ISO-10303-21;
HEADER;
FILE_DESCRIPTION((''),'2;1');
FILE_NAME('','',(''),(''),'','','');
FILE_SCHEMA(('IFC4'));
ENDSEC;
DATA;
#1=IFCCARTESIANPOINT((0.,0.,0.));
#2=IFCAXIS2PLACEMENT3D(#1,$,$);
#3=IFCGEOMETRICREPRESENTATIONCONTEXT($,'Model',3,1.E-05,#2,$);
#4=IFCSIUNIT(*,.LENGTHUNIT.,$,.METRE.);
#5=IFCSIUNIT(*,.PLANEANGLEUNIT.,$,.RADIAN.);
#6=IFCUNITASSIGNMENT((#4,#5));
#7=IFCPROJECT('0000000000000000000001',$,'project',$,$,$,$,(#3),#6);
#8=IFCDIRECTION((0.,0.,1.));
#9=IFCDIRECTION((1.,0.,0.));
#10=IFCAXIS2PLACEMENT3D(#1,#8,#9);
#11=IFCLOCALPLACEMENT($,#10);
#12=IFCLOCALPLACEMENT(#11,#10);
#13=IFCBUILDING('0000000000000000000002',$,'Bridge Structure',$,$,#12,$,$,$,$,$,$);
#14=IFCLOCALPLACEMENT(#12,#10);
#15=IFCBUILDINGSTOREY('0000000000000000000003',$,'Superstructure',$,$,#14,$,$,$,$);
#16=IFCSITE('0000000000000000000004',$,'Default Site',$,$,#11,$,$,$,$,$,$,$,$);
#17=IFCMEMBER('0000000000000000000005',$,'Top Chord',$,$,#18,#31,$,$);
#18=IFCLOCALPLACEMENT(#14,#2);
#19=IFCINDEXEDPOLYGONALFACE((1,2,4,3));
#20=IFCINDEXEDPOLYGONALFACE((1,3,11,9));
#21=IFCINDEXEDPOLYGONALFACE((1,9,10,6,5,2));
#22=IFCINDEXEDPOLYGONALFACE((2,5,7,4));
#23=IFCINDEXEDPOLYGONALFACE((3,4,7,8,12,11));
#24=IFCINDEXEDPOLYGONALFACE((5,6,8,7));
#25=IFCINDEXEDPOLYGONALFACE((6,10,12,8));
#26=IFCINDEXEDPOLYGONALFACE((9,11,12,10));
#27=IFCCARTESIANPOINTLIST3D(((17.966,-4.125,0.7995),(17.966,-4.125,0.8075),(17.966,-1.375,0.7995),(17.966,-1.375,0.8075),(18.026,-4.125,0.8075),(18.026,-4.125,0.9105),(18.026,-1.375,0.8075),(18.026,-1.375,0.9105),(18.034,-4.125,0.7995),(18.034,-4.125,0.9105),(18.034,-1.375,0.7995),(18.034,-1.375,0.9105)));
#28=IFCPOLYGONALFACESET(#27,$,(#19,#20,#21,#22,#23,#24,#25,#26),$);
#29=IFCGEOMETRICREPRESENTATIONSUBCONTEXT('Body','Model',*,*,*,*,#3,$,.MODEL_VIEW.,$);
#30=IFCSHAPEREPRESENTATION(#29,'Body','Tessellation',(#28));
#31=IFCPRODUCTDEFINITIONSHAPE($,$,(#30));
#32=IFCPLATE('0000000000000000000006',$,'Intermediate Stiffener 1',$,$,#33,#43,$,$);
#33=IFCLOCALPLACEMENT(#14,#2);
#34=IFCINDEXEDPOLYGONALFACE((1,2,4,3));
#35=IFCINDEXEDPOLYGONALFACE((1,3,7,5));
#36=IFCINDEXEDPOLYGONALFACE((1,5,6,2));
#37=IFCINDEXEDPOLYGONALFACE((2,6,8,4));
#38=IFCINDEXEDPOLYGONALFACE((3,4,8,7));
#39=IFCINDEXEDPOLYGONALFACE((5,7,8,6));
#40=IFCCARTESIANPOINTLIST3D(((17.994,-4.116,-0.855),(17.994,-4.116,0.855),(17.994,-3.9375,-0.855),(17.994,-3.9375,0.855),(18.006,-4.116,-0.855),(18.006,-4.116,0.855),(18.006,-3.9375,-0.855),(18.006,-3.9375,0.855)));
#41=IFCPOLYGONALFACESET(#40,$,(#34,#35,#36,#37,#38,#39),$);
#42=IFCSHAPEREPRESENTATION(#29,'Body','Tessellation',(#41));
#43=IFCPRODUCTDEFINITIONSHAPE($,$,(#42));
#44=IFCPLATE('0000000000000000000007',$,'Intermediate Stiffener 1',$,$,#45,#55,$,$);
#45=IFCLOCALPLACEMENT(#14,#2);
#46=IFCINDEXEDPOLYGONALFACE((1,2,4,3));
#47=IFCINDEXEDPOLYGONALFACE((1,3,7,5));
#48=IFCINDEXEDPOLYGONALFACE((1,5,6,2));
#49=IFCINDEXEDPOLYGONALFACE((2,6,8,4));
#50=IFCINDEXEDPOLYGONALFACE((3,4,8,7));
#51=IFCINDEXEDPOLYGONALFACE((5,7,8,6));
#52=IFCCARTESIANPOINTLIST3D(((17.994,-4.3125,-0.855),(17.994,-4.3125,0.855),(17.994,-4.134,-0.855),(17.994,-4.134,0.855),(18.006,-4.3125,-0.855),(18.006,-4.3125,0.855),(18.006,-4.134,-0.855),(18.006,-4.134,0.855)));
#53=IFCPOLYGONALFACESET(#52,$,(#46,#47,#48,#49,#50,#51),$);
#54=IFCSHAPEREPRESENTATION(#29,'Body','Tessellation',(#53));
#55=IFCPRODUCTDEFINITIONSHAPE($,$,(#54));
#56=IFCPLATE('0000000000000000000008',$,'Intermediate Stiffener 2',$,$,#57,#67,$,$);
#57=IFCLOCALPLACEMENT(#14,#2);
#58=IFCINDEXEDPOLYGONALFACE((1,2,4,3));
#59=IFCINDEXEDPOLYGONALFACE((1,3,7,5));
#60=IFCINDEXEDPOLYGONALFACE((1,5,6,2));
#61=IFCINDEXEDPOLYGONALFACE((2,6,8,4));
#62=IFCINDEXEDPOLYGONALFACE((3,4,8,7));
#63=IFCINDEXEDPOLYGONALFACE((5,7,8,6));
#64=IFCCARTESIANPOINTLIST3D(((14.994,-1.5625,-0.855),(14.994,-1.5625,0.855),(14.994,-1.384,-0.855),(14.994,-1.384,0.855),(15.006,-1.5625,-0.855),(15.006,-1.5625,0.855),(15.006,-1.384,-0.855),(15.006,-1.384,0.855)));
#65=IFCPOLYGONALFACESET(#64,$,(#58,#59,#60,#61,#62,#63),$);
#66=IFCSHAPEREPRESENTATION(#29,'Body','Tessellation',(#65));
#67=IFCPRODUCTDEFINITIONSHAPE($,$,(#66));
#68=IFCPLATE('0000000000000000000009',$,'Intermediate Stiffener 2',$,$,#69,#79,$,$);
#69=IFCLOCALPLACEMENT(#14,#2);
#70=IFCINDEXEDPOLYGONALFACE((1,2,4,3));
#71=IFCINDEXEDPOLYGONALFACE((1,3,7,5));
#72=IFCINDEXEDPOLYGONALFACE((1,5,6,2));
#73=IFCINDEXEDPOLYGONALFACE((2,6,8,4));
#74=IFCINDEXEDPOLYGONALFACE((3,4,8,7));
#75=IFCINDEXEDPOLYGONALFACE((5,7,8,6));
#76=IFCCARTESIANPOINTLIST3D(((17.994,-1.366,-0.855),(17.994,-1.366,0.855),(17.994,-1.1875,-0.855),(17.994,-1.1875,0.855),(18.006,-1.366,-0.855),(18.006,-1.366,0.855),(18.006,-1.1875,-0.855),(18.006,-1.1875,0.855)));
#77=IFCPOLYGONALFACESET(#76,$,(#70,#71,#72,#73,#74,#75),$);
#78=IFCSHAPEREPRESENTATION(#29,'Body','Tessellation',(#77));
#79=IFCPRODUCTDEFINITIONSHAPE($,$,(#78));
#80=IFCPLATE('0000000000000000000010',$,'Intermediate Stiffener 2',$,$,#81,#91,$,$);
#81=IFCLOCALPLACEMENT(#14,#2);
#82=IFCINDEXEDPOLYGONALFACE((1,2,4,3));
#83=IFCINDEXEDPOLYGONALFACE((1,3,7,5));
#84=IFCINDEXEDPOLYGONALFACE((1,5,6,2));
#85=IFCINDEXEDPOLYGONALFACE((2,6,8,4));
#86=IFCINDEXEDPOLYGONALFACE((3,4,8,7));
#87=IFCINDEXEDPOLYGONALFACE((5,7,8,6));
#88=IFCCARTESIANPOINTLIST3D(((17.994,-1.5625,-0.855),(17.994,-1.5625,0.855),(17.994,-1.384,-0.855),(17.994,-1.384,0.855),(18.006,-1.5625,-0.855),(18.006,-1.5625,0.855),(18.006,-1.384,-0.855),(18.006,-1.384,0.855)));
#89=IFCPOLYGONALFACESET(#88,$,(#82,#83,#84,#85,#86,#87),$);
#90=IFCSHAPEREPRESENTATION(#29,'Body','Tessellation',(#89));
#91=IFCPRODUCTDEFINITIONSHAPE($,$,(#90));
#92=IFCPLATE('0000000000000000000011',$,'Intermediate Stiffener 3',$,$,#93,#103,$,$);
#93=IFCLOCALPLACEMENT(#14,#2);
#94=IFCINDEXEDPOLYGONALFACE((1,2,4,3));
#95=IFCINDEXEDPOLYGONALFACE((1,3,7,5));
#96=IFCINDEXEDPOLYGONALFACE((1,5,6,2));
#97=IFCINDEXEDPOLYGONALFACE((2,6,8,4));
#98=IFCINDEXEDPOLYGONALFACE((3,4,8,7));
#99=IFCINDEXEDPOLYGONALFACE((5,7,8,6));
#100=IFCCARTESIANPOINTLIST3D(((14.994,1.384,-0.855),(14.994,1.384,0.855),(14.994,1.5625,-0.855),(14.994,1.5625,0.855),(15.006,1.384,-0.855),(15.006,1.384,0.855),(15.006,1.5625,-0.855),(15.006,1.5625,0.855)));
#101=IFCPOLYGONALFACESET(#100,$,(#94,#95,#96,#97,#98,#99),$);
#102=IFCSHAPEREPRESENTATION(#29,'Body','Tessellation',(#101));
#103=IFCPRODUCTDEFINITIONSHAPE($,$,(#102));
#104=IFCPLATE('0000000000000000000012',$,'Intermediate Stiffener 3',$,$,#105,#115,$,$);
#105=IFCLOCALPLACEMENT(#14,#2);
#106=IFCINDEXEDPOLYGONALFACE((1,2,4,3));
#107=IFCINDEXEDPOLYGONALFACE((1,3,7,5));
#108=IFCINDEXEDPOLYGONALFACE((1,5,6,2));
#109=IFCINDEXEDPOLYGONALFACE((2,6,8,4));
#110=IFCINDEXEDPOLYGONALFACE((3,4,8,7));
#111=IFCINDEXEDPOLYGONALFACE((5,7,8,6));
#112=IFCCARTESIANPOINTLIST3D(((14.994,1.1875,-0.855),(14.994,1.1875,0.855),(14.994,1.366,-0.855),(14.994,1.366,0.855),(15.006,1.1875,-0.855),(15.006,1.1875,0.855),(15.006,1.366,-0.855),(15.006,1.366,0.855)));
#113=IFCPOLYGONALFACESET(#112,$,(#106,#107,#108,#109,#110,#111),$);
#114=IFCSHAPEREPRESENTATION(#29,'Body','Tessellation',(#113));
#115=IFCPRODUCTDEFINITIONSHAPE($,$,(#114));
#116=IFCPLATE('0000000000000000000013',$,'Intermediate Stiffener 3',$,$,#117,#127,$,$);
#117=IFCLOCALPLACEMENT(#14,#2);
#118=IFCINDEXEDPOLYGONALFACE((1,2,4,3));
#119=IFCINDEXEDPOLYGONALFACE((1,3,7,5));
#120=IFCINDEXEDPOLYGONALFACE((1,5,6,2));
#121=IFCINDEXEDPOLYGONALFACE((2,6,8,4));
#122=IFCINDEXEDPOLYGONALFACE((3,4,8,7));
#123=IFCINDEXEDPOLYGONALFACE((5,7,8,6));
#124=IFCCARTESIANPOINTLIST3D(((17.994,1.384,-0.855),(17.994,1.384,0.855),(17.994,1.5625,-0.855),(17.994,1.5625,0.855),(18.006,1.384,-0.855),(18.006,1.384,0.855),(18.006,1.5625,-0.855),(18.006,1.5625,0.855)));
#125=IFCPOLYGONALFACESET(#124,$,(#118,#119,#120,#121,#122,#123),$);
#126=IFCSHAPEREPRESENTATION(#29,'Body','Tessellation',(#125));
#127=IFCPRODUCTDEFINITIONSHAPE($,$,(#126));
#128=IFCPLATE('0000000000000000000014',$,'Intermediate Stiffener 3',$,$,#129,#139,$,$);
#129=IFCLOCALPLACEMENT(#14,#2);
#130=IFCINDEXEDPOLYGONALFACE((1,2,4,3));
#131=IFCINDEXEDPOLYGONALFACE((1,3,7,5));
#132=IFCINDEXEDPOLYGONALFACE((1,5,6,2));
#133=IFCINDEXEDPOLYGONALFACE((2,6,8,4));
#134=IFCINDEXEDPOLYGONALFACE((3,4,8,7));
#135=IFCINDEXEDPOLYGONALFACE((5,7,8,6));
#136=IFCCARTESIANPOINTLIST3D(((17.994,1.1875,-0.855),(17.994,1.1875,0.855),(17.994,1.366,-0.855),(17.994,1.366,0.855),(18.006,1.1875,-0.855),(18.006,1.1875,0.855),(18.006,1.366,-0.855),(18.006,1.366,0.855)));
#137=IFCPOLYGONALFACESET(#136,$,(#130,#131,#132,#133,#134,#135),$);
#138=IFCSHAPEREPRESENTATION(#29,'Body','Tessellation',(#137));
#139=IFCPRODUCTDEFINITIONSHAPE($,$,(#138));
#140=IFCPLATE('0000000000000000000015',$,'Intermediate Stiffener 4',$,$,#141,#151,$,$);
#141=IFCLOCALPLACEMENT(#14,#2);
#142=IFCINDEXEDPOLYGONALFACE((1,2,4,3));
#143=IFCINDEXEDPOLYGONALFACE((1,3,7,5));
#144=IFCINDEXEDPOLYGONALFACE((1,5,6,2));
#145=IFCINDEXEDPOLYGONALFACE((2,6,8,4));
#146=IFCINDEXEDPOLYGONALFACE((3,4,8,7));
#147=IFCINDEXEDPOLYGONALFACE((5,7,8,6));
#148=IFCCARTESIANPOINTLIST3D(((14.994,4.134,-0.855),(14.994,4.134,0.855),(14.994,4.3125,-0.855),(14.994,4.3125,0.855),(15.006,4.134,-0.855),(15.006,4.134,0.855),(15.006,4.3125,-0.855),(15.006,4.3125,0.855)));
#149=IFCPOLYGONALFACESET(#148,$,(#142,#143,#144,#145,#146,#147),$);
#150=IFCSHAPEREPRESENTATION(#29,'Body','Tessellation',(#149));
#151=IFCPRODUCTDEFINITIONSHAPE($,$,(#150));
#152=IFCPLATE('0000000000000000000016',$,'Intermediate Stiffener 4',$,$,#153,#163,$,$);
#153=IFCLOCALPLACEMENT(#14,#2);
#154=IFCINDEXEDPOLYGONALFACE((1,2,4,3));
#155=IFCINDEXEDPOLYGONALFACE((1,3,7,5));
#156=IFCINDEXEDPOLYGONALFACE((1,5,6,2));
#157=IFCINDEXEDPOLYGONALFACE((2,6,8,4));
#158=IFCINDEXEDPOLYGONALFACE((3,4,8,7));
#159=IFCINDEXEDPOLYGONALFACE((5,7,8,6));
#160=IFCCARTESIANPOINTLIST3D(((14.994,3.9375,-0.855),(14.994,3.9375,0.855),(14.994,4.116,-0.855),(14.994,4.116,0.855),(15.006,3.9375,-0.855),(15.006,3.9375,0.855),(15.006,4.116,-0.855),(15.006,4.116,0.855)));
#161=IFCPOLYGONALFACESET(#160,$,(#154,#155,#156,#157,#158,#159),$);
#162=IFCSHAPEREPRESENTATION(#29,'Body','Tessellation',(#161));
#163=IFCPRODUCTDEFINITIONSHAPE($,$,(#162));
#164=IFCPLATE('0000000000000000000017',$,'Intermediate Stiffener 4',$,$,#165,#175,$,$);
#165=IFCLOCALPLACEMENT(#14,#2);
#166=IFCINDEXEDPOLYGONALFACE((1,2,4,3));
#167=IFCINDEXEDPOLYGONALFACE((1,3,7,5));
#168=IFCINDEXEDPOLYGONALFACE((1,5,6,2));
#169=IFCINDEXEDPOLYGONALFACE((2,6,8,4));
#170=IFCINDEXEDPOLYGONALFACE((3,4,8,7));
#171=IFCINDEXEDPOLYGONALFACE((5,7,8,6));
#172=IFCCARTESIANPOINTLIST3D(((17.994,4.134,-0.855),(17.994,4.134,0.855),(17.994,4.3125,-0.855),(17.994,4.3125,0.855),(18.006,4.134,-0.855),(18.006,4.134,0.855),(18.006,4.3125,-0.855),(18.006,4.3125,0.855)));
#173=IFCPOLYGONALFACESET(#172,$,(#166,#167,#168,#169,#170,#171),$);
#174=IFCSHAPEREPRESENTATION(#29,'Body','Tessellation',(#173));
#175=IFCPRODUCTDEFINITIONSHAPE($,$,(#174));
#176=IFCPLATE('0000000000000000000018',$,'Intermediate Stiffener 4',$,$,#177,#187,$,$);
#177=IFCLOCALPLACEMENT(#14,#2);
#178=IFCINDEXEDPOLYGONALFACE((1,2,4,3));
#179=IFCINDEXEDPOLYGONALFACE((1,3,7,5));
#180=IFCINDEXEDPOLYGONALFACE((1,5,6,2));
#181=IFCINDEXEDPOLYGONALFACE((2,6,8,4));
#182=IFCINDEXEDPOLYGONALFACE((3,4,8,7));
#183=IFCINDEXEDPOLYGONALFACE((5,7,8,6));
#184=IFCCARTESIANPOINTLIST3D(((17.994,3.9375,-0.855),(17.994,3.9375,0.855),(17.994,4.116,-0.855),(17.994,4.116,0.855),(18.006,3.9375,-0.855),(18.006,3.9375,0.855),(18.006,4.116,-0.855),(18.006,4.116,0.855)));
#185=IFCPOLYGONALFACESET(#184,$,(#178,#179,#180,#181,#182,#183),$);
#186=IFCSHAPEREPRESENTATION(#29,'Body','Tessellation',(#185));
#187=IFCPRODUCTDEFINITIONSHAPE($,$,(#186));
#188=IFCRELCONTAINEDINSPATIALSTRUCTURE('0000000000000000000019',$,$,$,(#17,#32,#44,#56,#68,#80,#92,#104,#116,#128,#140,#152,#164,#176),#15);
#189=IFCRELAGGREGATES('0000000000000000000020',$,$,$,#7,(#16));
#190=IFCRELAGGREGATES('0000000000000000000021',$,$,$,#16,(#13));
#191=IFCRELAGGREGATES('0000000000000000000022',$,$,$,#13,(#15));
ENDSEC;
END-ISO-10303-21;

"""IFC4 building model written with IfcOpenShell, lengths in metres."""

from ifc_helpers import new_model, si_unit, frame, origin, origin_with_axes, origin_2d_with_axis, place, context, subcontext, project, spatial, rectangle, l_section, extrude, element, save


model = new_model("IFC4")

# Units and contexts
model_context = context("Model", 3, precision=1e-05, world=origin())
body_context = subcontext(model_context, "Body", "Model", "MODEL_VIEW")
ifc_project = project(units=[si_unit("LENGTHUNIT", "METRE"), si_unit("PLANEANGLEUNIT", "RADIAN")], contexts=[model_context])

# Site, building, storey
site_placement = place(None, origin_with_axes())
site = spatial("IfcSite", under=ifc_project, at=site_placement, Name="Default Site")
building_placement = place(site_placement, origin_with_axes())
building = spatial("IfcBuilding", under=site, at=building_placement, Name="Bridge Structure")
storey_placement = place(building_placement, origin_with_axes())
storey = spatial("IfcBuildingStorey", under=building, at=storey_placement, Name="Superstructure")

# Member
for number, where, z_axis, x_axis, name in (
    (1, (18.0, -4.125, 0.855), (0.0, 1.0, 0.0), (-1.0, 0.0, 0.0), "Top Chord"),
):
    element("IfcMember", number, at=place(storey_placement, frame(where, z_axis=z_axis, x_axis=x_axis)), inside=storey, Name=name, context=body_context, shape_type="SweptSolid", body=[
        extrude(l_section(Depth=0.111, Width=0.068, Thickness=0.008, at=origin_2d_with_axis()), origin_with_axes(), (0.0, 0.0, 1.0), 2.75),
    ])

# Plates
for number, where, z_axis, x_axis, name in (
    (2, (18.0, -4.0267, -0.855), (0.0, 0.0, 1.0), (1.0, 0.0, 0.0), "Intermediate Stiffener 1"),
    (3, (18.0, -4.2233, -0.855), (0.0, 0.0, 1.0), (1.0, 0.0, 0.0), "Intermediate Stiffener 1"),
    (4, (15.0, -1.4732, -0.855), (0.0, 0.0, 1.0), (1.0, 0.0, 0.0), "Intermediate Stiffener 2"),
    (5, (18.0, -1.2768, -0.855), (0.0, 0.0, 1.0), (1.0, 0.0, 0.0), "Intermediate Stiffener 2"),
    (6, (18.0, -1.4732, -0.855), (0.0, 0.0, 1.0), (1.0, 0.0, 0.0), "Intermediate Stiffener 2"),
    (7, (15.0, 1.4732, -0.855), (0.0, 0.0, 1.0), (1.0, 0.0, 0.0), "Intermediate Stiffener 3"),
    (8, (15.0, 1.2768, -0.855), (0.0, 0.0, 1.0), (1.0, 0.0, 0.0), "Intermediate Stiffener 3"),
    (9, (18.0, 1.4732, -0.855), (0.0, 0.0, 1.0), (1.0, 0.0, 0.0), "Intermediate Stiffener 3"),
    (10, (18.0, 1.2768, -0.855), (0.0, 0.0, 1.0), (1.0, 0.0, 0.0), "Intermediate Stiffener 3"),
    (11, (15.0, 4.2233, -0.855), (0.0, 0.0, 1.0), (1.0, 0.0, 0.0), "Intermediate Stiffener 4"),
    (12, (15.0, 4.0267, -0.855), (0.0, 0.0, 1.0), (1.0, 0.0, 0.0), "Intermediate Stiffener 4"),
    (13, (18.0, 4.2233, -0.855), (0.0, 0.0, 1.0), (1.0, 0.0, 0.0), "Intermediate Stiffener 4"),
    (14, (18.0, 4.0267, -0.855), (0.0, 0.0, 1.0), (1.0, 0.0, 0.0), "Intermediate Stiffener 4"),
):
    element("IfcPlate", number, at=place(storey_placement, frame(where, z_axis=z_axis, x_axis=x_axis)), inside=storey, Name=name, context=body_context, shape_type="SweptSolid", body=[
        extrude(rectangle(XDim=0.012, YDim=0.1785, at=origin_2d_with_axis()), origin_with_axes(), (0.0, 0.0, 1.0), 1.71),
    ])

save(model, "model.ifc")
